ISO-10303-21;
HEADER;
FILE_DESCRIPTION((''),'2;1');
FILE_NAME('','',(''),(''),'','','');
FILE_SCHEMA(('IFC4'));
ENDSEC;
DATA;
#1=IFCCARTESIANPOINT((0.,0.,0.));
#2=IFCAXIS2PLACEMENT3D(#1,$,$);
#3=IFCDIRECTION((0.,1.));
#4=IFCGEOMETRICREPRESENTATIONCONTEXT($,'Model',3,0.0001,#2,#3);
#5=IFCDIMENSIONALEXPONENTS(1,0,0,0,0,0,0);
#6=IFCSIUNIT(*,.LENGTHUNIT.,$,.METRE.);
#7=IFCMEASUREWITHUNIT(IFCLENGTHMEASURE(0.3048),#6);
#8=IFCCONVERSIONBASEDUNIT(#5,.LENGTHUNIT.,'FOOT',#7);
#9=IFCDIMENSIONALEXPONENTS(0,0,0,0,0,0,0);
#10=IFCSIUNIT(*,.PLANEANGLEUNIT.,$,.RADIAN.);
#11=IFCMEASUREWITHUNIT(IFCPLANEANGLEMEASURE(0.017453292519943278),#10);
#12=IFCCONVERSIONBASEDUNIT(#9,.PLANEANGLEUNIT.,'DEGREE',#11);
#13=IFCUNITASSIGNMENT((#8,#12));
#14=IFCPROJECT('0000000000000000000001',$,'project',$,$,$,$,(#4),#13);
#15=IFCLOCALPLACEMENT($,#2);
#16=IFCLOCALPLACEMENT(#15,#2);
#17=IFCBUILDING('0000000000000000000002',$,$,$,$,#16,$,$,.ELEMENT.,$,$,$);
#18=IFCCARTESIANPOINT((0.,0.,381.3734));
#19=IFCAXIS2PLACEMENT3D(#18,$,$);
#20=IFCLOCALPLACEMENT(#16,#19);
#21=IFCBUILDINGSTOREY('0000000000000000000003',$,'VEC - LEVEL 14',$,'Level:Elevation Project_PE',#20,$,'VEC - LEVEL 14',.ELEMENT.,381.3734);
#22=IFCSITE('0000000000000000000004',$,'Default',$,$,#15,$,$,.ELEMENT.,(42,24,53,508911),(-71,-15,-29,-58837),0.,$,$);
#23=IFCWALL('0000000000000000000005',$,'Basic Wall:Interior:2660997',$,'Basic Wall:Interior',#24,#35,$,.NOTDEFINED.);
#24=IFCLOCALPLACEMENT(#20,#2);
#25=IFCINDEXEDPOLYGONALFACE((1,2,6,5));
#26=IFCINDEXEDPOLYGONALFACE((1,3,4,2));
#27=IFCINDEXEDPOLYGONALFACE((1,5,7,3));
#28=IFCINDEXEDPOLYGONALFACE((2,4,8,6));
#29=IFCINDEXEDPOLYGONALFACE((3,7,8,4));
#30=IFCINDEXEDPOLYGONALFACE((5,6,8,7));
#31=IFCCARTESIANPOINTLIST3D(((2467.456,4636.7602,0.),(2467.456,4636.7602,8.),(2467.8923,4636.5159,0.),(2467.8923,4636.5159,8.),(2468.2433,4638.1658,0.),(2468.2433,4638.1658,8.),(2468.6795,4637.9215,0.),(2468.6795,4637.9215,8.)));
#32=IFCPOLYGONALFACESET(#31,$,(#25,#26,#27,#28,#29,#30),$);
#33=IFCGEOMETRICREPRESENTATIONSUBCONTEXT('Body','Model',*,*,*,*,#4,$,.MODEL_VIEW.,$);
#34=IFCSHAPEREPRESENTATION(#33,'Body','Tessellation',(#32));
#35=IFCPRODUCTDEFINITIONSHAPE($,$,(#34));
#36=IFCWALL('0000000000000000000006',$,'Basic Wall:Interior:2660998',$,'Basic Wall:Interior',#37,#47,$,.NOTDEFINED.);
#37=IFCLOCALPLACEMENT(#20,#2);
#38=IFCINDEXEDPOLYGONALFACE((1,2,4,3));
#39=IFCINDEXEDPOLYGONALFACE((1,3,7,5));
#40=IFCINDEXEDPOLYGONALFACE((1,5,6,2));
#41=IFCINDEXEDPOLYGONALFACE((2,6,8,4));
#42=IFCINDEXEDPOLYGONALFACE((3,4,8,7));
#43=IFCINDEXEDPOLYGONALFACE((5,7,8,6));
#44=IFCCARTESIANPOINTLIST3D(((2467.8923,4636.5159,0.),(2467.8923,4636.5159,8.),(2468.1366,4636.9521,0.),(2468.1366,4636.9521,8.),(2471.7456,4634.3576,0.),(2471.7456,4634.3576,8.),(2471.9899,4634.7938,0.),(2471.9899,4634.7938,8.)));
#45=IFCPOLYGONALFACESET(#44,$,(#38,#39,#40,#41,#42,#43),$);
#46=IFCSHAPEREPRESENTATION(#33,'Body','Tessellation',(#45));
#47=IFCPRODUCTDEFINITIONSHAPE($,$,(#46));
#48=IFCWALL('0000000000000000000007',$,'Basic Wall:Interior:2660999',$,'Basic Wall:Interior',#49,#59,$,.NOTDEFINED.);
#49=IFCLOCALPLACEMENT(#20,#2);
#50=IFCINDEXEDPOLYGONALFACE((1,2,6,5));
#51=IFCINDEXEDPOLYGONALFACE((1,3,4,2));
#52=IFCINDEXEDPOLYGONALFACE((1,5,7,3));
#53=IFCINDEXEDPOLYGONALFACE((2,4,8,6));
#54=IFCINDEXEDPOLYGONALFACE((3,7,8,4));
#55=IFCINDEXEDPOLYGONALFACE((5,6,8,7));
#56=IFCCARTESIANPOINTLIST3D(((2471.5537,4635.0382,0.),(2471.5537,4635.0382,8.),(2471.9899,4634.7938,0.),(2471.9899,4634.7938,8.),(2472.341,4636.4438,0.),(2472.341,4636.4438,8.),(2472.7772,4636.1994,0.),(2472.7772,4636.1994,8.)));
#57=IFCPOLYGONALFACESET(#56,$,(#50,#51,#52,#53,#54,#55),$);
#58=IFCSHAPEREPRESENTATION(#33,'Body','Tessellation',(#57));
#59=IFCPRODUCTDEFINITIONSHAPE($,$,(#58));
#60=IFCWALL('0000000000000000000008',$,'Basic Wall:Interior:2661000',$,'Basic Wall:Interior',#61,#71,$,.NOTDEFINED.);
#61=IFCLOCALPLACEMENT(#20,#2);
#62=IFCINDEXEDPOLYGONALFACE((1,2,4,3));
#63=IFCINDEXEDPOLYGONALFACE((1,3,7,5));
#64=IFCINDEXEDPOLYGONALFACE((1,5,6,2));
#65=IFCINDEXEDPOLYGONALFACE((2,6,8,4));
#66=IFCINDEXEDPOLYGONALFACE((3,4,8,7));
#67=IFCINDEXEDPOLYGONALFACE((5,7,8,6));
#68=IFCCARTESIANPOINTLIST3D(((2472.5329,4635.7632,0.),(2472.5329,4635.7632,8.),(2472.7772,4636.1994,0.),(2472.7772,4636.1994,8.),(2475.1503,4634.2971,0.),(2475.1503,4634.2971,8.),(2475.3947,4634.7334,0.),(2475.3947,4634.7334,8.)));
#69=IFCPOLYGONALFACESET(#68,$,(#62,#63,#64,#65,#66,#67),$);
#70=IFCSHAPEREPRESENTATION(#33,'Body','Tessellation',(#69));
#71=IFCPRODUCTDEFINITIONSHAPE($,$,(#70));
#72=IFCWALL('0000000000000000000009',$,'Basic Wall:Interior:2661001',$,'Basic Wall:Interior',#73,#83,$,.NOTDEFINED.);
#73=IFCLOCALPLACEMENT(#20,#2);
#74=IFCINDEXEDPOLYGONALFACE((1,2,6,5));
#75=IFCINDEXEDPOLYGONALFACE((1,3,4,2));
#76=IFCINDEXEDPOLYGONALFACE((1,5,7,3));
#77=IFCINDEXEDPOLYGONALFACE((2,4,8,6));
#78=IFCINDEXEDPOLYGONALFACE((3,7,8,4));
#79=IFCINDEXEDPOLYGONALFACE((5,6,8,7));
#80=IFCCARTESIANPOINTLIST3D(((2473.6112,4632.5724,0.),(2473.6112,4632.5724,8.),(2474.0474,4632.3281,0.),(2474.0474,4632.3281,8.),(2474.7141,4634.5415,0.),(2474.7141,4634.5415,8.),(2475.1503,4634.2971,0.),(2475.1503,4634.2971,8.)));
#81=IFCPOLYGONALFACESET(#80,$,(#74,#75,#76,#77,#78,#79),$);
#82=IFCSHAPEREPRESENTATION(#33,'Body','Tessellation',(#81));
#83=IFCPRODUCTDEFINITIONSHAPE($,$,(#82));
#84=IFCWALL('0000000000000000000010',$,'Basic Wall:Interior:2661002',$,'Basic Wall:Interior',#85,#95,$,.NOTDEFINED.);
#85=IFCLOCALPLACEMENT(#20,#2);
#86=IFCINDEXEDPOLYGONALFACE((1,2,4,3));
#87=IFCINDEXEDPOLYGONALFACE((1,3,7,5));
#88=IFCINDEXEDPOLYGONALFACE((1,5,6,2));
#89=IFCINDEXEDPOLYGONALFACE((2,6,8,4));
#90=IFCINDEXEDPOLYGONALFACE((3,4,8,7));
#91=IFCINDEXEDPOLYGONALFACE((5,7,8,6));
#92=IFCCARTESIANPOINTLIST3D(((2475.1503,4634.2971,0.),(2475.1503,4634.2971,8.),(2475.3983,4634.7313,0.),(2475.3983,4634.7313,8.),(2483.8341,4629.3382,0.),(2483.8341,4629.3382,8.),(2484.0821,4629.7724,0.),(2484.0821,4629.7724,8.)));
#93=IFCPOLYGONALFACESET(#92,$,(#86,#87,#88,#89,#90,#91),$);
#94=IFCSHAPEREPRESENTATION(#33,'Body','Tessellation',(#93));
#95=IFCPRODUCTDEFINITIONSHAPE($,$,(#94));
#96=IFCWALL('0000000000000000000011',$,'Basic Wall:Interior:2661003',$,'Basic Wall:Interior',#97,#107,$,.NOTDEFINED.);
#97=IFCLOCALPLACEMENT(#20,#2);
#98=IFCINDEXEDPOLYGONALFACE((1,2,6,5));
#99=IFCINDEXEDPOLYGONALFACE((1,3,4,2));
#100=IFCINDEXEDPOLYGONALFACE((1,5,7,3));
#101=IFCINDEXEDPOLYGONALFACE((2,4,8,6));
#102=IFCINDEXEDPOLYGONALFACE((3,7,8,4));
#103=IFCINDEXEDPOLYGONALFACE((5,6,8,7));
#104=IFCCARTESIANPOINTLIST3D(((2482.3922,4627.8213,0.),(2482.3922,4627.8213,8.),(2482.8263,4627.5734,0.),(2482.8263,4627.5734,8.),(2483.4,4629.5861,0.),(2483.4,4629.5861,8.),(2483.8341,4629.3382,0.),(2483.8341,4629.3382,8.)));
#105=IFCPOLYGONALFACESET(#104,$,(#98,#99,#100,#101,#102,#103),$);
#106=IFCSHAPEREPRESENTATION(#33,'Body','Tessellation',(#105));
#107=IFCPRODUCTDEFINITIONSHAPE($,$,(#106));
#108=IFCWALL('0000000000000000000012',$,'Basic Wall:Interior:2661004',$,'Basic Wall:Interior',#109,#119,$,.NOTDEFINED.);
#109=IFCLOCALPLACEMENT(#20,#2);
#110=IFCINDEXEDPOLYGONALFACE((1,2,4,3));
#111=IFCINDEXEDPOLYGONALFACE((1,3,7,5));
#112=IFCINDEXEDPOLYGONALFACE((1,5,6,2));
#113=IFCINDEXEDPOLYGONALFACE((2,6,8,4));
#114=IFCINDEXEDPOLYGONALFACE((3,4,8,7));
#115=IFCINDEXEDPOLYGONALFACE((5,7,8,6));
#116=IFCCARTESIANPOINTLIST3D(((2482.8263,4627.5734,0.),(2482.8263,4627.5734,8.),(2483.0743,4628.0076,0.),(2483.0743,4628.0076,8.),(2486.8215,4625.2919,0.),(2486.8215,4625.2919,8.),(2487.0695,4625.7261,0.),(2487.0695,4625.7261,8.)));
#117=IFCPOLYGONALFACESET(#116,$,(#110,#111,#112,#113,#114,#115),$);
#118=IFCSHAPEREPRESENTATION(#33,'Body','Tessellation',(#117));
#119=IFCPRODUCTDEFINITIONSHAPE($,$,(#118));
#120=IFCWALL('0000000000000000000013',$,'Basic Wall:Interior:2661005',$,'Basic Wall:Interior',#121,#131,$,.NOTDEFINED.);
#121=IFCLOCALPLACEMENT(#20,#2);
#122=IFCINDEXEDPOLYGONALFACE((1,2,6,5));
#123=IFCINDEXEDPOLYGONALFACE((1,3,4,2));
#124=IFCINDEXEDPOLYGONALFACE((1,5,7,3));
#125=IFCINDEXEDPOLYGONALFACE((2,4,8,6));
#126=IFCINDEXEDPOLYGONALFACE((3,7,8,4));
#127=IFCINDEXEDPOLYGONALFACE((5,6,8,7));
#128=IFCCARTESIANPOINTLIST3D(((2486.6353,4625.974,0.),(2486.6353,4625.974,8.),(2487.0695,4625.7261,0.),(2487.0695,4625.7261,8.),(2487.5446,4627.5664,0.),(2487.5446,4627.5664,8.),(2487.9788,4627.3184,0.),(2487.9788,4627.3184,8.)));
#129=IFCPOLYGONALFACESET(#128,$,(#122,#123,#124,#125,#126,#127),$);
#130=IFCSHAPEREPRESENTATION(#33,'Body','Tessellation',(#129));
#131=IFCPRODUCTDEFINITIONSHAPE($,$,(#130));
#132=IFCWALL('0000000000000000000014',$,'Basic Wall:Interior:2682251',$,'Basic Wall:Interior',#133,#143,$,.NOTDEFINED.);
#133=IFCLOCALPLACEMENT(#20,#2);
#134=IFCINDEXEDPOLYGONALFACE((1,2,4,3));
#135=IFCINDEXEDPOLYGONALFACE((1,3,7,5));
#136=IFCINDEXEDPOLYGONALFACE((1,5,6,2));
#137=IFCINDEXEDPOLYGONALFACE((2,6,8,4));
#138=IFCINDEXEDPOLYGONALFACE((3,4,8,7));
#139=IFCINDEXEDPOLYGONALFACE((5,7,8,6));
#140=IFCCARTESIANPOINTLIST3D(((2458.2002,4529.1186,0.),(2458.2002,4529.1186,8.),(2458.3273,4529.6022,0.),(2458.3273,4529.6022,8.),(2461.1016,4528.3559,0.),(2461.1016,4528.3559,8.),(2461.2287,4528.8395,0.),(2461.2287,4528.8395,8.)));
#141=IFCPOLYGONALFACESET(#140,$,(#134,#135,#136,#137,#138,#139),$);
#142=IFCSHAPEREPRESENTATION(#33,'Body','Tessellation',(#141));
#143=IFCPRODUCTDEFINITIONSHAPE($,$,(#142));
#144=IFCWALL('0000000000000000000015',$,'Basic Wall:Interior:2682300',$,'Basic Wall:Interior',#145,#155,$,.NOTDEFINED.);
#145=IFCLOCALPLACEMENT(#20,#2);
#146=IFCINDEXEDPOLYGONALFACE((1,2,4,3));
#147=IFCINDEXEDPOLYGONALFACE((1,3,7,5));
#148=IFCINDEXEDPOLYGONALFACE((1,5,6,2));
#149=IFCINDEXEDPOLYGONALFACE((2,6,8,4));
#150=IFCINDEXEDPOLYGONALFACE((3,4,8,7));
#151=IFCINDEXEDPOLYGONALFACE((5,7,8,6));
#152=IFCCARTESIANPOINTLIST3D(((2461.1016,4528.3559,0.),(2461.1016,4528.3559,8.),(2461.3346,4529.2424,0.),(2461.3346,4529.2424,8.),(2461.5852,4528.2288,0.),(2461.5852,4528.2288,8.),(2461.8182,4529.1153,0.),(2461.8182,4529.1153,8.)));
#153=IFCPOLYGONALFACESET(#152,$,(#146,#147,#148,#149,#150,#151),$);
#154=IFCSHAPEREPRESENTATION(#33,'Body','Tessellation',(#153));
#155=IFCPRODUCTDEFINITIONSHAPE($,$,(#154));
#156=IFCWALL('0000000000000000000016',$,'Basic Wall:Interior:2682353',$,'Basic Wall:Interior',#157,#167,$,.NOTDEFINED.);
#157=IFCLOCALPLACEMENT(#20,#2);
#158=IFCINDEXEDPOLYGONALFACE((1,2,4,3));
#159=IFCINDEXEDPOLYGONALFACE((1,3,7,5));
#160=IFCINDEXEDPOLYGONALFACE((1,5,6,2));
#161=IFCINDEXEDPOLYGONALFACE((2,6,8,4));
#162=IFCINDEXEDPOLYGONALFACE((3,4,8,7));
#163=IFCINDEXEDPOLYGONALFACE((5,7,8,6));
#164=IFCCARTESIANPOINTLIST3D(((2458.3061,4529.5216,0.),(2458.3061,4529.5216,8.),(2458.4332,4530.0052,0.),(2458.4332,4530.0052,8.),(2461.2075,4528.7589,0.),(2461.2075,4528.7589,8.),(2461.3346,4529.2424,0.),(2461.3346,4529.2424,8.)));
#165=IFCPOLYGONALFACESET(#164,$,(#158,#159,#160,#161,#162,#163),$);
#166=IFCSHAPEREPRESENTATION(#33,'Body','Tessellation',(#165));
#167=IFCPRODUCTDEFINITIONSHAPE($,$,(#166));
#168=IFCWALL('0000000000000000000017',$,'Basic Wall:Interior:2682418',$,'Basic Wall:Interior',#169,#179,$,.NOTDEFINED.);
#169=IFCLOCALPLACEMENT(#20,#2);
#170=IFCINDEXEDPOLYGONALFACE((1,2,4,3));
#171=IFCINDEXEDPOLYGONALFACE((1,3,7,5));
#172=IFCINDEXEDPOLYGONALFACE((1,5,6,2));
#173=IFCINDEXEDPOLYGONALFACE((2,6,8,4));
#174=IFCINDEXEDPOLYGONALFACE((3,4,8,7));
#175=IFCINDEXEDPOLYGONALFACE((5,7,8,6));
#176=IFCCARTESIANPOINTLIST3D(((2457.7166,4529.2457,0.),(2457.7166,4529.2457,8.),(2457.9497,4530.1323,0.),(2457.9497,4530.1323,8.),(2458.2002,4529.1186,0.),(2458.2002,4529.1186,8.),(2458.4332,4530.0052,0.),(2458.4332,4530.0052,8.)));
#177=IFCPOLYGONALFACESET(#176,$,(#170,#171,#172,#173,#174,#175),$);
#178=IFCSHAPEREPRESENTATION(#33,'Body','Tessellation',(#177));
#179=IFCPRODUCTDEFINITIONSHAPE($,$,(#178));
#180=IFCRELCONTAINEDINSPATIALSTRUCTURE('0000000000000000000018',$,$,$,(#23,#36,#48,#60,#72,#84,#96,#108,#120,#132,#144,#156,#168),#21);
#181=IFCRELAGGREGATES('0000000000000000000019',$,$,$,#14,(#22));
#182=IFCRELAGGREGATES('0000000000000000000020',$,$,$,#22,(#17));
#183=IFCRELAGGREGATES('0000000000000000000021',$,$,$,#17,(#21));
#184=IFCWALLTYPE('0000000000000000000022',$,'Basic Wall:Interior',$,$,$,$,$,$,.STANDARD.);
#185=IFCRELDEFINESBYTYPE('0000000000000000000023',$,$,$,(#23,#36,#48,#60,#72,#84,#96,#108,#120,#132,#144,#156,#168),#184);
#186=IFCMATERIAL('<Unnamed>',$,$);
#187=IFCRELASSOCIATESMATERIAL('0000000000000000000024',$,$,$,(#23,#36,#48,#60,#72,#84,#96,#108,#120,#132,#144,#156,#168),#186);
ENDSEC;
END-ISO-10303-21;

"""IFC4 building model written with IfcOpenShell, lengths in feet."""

from ifc_helpers import new_model, entity, si_unit, converted_unit, direction, frame, origin, place, context, subcontext, project, spatial, indexed_curve, outline, extrude, material, type_object, element, save


model = new_model("IFC4")

# Units and contexts
model_context = context("Model", 3, precision=0.0001, world=origin(), true_north=direction((0.0, 1.0)))
body_context = subcontext(model_context, "Body", "Model", "MODEL_VIEW")
ifc_project = project(units=[converted_unit("LENGTHUNIT", "FOOT", entity("IfcLengthMeasure", 0.3048), si_unit("LENGTHUNIT", "METRE"), dimensions=[1, 0, 0, 0, 0, 0, 0]), converted_unit("PLANEANGLEUNIT", "DEGREE", entity("IfcPlaneAngleMeasure", 0.017453292519943278), si_unit("PLANEANGLEUNIT", "RADIAN"), dimensions=[0, 0, 0, 0, 0, 0, 0])], contexts=[model_context])

# Site, building, storey
site_placement = place(None, origin())
site = spatial("IfcSite", under=ifc_project, at=site_placement, Name="Default", CompositionType="ELEMENT", RefLatitude=(42, 24, 53, 508911), RefLongitude=(-71, -15, -29, -58837), RefElevation=0.0)
building_placement = place(site_placement, origin())
building = spatial("IfcBuilding", under=site, at=building_placement, CompositionType="ELEMENT")
storey_placement = place(building_placement, frame((0.0, 0.0, 381.3734)))
storey = spatial("IfcBuildingStorey", under=building, at=storey_placement, Name="VEC - LEVEL 14", ObjectType="Level:Elevation Project_PE", LongName="VEC - LEVEL 14", CompositionType="ELEMENT", Elevation=381.3734)

# Walls
ifc_material_1 = material(Name="<Unnamed>")
wall_type = type_object("IfcWallType", Name="Basic Wall:Interior", PredefinedType="STANDARD")
wall_1_placement = place(storey_placement, frame((2468.4614, 4638.0436, 0.0), z_axis=(0.0, 0.0, 1.0), x_axis=(-0.488675, -0.872466, 0.0)))
element("IfcWall", 1, at=wall_1_placement, inside=storey, type_object=wall_type, material=ifc_material_1, Name="Basic Wall:Interior:2660997", ObjectType="Basic Wall:Interior", PredefinedType="NOTDEFINED", context=body_context, shape_type="SweptSolid", body=[
    extrude(outline(indexed_curve([(1.611, 0.25), (0.0, 0.25), (0.0, -0.25), (1.611, -0.25), (1.611, 0.25)], self_intersect=False)), origin(), (0.0, 0.0, 1.0), 8.0),
])
wall_2_placement = place(storey_placement, frame((2468.0144, 4636.734, 0.0), z_axis=(0.0, 0.0, 1.0), x_axis=(0.872466, -0.488675, 0.0)))
element("IfcWall", 2, at=wall_2_placement, inside=storey, type_object=wall_type, material=ifc_material_1, Name="Basic Wall:Interior:2660998", ObjectType="Basic Wall:Interior", PredefinedType="NOTDEFINED", context=body_context, shape_type="SweptSolid", body=[
    extrude(outline(indexed_curve([(4.4166, 0.25), (0.0, 0.25), (0.0, -0.25), (4.4166, -0.25), (4.4166, 0.25)], self_intersect=False)), origin(), (0.0, 0.0, 1.0), 8.0),
])
wall_3_placement = place(storey_placement, frame((2471.7718, 4634.916, 0.0), z_axis=(0.0, 0.0, 1.0), x_axis=(0.488675, 0.872466, 0.0)))
element("IfcWall", 3, at=wall_3_placement, inside=storey, type_object=wall_type, material=ifc_material_1, Name="Basic Wall:Interior:2660999", ObjectType="Basic Wall:Interior", PredefinedType="NOTDEFINED", context=body_context, shape_type="SweptSolid", body=[
    extrude(outline(indexed_curve([(1.611, 0.25), (0.0, 0.25), (0.0, -0.25), (1.611, -0.25), (1.611, 0.25)], self_intersect=False)), origin(), (0.0, 0.0, 1.0), 8.0),
])
wall_4_placement = place(storey_placement, frame((2472.655, 4635.9813, 0.0), z_axis=(0.0, 0.0, 1.0), x_axis=(0.872466, -0.488675, 0.0)))
element("IfcWall", 4, at=wall_4_placement, inside=storey, type_object=wall_type, material=ifc_material_1, Name="Basic Wall:Interior:2661000", ObjectType="Basic Wall:Interior", PredefinedType="NOTDEFINED", context=body_context, shape_type="SweptSolid", body=[
    extrude(outline(indexed_curve([(3.0001, 0.25), (0.0, 0.25), (0.0, -0.25), (3.0001, -0.25), (3.0001, 0.25)], self_intersect=False)), origin(), (0.0, 0.0, 1.0), 8.0),
])
wall_5_placement = place(storey_placement, frame((2474.9322, 4634.4193, 0.0), z_axis=(0.0, 0.0, 1.0), x_axis=(-0.488675, -0.872466, 0.0)))
element("IfcWall", 5, at=wall_5_placement, inside=storey, type_object=wall_type, material=ifc_material_1, Name="Basic Wall:Interior:2661001", ObjectType="Basic Wall:Interior", PredefinedType="NOTDEFINED", context=body_context, shape_type="SweptSolid", body=[
    extrude(outline(indexed_curve([(2.2569, 0.25), (0.0, 0.25), (0.0, -0.25), (2.2569, -0.25), (2.2569, 0.25)], self_intersect=False)), origin(), (0.0, 0.0, 1.0), 8.0),
])
wall_6_placement = place(storey_placement, frame((2475.2743, 4634.5142, 0.0), z_axis=(0.0, 0.0, 1.0), x_axis=(0.868382, -0.495895, 0.0)))
element("IfcWall", 6, at=wall_6_placement, inside=storey, type_object=wall_type, material=ifc_material_1, Name="Basic Wall:Interior:2661002", ObjectType="Basic Wall:Interior", PredefinedType="NOTDEFINED", context=body_context, shape_type="SweptSolid", body=[
    extrude(outline(indexed_curve([(10.0, 0.25), (0.0, 0.25), (0.0, -0.25), (10.0, -0.25), (10.0, 0.25)], self_intersect=False)), origin(), (0.0, 0.0, 1.0), 8.0),
])
wall_7_placement = place(storey_placement, frame((2483.617, 4629.4622, 0.0), z_axis=(0.0, 0.0, 1.0), x_axis=(-0.495895, -0.868382, 0.0)))
element("IfcWall", 7, at=wall_7_placement, inside=storey, type_object=wall_type, material=ifc_material_1, Name="Basic Wall:Interior:2661003", ObjectType="Basic Wall:Interior", PredefinedType="NOTDEFINED", context=body_context, shape_type="SweptSolid", body=[
    extrude(outline(indexed_curve([(2.0323, 0.25), (0.0, 0.25), (0.0, -0.25), (2.0323, -0.25), (2.0323, 0.25)], self_intersect=False)), origin(), (0.0, 0.0, 1.0), 8.0),
])
wall_8_placement = place(storey_placement, frame((2482.9503, 4627.7905, 0.0), z_axis=(0.0, 0.0, 1.0), x_axis=(0.868382, -0.495895, 0.0)))
element("IfcWall", 8, at=wall_8_placement, inside=storey, type_object=wall_type, material=ifc_material_1, Name="Basic Wall:Interior:2661004", ObjectType="Basic Wall:Interior", PredefinedType="NOTDEFINED", context=body_context, shape_type="SweptSolid", body=[
    extrude(outline(indexed_curve([(4.6007, 0.25), (0.0, 0.25), (0.0, -0.25), (4.6007, -0.25), (4.6007, 0.25)], self_intersect=False)), origin(), (0.0, 0.0, 1.0), 8.0),
])
wall_9_placement = place(storey_placement, frame((2486.8524, 4625.8501, 0.0), z_axis=(0.0, 0.0, 1.0), x_axis=(0.495895, 0.868382, 0.0)))
element("IfcWall", 9, at=wall_9_placement, inside=storey, type_object=wall_type, material=ifc_material_1, Name="Basic Wall:Interior:2661005", ObjectType="Basic Wall:Interior", PredefinedType="NOTDEFINED", context=body_context, shape_type="SweptSolid", body=[
    extrude(outline(indexed_curve([(1.8337, 0.25), (0.0, 0.25), (0.0, -0.25), (1.8337, -0.25), (1.8337, 0.25)], self_intersect=False)), origin(), (0.0, 0.0, 1.0), 8.0),
])
wall_10_placement = place(storey_placement, frame((2458.2637, 4529.3604, 0.0), z_axis=(0.0, 0.0, 1.0), x_axis=(0.96714, -0.254244, 0.0)))
element("IfcWall", 10, at=wall_10_placement, inside=storey, type_object=wall_type, material=ifc_material_1, Name="Basic Wall:Interior:2682251", ObjectType="Basic Wall:Interior", PredefinedType="NOTDEFINED", context=body_context, shape_type="SweptSolid", body=[
    extrude(outline(indexed_curve([(3.0, 0.25), (0.0, 0.25), (0.0, -0.25), (3.0, -0.25), (3.0, 0.25)], self_intersect=False)), origin(), (0.0, 0.0, 1.0), 8.0),
])
wall_11_placement = place(storey_placement, frame((2461.3434, 4528.2923, 0.0), z_axis=(0.0, 0.0, 1.0), x_axis=(0.254244, 0.96714, 0.0)))
element("IfcWall", 11, at=wall_11_placement, inside=storey, type_object=wall_type, material=ifc_material_1, Name="Basic Wall:Interior:2682300", ObjectType="Basic Wall:Interior", PredefinedType="NOTDEFINED", context=body_context, shape_type="SweptSolid", body=[
    extrude(outline(indexed_curve([(0.9167, 0.25), (0.0, 0.25), (0.0, -0.25), (0.9167, -0.25), (0.9167, 0.25)], self_intersect=False)), origin(), (0.0, 0.0, 1.0), 8.0),
])
wall_12_placement = place(storey_placement, frame((2461.2711, 4529.0007, 0.0), z_axis=(0.0, 0.0, 1.0), x_axis=(-0.96714, 0.254244, 0.0)))
element("IfcWall", 12, at=wall_12_placement, inside=storey, type_object=wall_type, material=ifc_material_1, Name="Basic Wall:Interior:2682353", ObjectType="Basic Wall:Interior", PredefinedType="NOTDEFINED", context=body_context, shape_type="SweptSolid", body=[
    extrude(outline(indexed_curve([(3.0, 0.25), (0.0, 0.25), (0.0, -0.25), (3.0, -0.25), (3.0, 0.25)], self_intersect=False)), origin(), (0.0, 0.0, 1.0), 8.0),
])
wall_13_placement = place(storey_placement, frame((2458.1914, 4530.0687, 0.0), z_axis=(0.0, 0.0, 1.0), x_axis=(-0.254244, -0.96714, 0.0)))
element("IfcWall", 13, at=wall_13_placement, inside=storey, type_object=wall_type, material=ifc_material_1, Name="Basic Wall:Interior:2682418", ObjectType="Basic Wall:Interior", PredefinedType="NOTDEFINED", context=body_context, shape_type="SweptSolid", body=[
    extrude(outline(indexed_curve([(0.9167, 0.25), (0.0, 0.25), (0.0, -0.25), (0.9167, -0.25), (0.9167, 0.25)], self_intersect=False)), origin(), (0.0, 0.0, 1.0), 8.0),
])

save(model, "model.ifc")
